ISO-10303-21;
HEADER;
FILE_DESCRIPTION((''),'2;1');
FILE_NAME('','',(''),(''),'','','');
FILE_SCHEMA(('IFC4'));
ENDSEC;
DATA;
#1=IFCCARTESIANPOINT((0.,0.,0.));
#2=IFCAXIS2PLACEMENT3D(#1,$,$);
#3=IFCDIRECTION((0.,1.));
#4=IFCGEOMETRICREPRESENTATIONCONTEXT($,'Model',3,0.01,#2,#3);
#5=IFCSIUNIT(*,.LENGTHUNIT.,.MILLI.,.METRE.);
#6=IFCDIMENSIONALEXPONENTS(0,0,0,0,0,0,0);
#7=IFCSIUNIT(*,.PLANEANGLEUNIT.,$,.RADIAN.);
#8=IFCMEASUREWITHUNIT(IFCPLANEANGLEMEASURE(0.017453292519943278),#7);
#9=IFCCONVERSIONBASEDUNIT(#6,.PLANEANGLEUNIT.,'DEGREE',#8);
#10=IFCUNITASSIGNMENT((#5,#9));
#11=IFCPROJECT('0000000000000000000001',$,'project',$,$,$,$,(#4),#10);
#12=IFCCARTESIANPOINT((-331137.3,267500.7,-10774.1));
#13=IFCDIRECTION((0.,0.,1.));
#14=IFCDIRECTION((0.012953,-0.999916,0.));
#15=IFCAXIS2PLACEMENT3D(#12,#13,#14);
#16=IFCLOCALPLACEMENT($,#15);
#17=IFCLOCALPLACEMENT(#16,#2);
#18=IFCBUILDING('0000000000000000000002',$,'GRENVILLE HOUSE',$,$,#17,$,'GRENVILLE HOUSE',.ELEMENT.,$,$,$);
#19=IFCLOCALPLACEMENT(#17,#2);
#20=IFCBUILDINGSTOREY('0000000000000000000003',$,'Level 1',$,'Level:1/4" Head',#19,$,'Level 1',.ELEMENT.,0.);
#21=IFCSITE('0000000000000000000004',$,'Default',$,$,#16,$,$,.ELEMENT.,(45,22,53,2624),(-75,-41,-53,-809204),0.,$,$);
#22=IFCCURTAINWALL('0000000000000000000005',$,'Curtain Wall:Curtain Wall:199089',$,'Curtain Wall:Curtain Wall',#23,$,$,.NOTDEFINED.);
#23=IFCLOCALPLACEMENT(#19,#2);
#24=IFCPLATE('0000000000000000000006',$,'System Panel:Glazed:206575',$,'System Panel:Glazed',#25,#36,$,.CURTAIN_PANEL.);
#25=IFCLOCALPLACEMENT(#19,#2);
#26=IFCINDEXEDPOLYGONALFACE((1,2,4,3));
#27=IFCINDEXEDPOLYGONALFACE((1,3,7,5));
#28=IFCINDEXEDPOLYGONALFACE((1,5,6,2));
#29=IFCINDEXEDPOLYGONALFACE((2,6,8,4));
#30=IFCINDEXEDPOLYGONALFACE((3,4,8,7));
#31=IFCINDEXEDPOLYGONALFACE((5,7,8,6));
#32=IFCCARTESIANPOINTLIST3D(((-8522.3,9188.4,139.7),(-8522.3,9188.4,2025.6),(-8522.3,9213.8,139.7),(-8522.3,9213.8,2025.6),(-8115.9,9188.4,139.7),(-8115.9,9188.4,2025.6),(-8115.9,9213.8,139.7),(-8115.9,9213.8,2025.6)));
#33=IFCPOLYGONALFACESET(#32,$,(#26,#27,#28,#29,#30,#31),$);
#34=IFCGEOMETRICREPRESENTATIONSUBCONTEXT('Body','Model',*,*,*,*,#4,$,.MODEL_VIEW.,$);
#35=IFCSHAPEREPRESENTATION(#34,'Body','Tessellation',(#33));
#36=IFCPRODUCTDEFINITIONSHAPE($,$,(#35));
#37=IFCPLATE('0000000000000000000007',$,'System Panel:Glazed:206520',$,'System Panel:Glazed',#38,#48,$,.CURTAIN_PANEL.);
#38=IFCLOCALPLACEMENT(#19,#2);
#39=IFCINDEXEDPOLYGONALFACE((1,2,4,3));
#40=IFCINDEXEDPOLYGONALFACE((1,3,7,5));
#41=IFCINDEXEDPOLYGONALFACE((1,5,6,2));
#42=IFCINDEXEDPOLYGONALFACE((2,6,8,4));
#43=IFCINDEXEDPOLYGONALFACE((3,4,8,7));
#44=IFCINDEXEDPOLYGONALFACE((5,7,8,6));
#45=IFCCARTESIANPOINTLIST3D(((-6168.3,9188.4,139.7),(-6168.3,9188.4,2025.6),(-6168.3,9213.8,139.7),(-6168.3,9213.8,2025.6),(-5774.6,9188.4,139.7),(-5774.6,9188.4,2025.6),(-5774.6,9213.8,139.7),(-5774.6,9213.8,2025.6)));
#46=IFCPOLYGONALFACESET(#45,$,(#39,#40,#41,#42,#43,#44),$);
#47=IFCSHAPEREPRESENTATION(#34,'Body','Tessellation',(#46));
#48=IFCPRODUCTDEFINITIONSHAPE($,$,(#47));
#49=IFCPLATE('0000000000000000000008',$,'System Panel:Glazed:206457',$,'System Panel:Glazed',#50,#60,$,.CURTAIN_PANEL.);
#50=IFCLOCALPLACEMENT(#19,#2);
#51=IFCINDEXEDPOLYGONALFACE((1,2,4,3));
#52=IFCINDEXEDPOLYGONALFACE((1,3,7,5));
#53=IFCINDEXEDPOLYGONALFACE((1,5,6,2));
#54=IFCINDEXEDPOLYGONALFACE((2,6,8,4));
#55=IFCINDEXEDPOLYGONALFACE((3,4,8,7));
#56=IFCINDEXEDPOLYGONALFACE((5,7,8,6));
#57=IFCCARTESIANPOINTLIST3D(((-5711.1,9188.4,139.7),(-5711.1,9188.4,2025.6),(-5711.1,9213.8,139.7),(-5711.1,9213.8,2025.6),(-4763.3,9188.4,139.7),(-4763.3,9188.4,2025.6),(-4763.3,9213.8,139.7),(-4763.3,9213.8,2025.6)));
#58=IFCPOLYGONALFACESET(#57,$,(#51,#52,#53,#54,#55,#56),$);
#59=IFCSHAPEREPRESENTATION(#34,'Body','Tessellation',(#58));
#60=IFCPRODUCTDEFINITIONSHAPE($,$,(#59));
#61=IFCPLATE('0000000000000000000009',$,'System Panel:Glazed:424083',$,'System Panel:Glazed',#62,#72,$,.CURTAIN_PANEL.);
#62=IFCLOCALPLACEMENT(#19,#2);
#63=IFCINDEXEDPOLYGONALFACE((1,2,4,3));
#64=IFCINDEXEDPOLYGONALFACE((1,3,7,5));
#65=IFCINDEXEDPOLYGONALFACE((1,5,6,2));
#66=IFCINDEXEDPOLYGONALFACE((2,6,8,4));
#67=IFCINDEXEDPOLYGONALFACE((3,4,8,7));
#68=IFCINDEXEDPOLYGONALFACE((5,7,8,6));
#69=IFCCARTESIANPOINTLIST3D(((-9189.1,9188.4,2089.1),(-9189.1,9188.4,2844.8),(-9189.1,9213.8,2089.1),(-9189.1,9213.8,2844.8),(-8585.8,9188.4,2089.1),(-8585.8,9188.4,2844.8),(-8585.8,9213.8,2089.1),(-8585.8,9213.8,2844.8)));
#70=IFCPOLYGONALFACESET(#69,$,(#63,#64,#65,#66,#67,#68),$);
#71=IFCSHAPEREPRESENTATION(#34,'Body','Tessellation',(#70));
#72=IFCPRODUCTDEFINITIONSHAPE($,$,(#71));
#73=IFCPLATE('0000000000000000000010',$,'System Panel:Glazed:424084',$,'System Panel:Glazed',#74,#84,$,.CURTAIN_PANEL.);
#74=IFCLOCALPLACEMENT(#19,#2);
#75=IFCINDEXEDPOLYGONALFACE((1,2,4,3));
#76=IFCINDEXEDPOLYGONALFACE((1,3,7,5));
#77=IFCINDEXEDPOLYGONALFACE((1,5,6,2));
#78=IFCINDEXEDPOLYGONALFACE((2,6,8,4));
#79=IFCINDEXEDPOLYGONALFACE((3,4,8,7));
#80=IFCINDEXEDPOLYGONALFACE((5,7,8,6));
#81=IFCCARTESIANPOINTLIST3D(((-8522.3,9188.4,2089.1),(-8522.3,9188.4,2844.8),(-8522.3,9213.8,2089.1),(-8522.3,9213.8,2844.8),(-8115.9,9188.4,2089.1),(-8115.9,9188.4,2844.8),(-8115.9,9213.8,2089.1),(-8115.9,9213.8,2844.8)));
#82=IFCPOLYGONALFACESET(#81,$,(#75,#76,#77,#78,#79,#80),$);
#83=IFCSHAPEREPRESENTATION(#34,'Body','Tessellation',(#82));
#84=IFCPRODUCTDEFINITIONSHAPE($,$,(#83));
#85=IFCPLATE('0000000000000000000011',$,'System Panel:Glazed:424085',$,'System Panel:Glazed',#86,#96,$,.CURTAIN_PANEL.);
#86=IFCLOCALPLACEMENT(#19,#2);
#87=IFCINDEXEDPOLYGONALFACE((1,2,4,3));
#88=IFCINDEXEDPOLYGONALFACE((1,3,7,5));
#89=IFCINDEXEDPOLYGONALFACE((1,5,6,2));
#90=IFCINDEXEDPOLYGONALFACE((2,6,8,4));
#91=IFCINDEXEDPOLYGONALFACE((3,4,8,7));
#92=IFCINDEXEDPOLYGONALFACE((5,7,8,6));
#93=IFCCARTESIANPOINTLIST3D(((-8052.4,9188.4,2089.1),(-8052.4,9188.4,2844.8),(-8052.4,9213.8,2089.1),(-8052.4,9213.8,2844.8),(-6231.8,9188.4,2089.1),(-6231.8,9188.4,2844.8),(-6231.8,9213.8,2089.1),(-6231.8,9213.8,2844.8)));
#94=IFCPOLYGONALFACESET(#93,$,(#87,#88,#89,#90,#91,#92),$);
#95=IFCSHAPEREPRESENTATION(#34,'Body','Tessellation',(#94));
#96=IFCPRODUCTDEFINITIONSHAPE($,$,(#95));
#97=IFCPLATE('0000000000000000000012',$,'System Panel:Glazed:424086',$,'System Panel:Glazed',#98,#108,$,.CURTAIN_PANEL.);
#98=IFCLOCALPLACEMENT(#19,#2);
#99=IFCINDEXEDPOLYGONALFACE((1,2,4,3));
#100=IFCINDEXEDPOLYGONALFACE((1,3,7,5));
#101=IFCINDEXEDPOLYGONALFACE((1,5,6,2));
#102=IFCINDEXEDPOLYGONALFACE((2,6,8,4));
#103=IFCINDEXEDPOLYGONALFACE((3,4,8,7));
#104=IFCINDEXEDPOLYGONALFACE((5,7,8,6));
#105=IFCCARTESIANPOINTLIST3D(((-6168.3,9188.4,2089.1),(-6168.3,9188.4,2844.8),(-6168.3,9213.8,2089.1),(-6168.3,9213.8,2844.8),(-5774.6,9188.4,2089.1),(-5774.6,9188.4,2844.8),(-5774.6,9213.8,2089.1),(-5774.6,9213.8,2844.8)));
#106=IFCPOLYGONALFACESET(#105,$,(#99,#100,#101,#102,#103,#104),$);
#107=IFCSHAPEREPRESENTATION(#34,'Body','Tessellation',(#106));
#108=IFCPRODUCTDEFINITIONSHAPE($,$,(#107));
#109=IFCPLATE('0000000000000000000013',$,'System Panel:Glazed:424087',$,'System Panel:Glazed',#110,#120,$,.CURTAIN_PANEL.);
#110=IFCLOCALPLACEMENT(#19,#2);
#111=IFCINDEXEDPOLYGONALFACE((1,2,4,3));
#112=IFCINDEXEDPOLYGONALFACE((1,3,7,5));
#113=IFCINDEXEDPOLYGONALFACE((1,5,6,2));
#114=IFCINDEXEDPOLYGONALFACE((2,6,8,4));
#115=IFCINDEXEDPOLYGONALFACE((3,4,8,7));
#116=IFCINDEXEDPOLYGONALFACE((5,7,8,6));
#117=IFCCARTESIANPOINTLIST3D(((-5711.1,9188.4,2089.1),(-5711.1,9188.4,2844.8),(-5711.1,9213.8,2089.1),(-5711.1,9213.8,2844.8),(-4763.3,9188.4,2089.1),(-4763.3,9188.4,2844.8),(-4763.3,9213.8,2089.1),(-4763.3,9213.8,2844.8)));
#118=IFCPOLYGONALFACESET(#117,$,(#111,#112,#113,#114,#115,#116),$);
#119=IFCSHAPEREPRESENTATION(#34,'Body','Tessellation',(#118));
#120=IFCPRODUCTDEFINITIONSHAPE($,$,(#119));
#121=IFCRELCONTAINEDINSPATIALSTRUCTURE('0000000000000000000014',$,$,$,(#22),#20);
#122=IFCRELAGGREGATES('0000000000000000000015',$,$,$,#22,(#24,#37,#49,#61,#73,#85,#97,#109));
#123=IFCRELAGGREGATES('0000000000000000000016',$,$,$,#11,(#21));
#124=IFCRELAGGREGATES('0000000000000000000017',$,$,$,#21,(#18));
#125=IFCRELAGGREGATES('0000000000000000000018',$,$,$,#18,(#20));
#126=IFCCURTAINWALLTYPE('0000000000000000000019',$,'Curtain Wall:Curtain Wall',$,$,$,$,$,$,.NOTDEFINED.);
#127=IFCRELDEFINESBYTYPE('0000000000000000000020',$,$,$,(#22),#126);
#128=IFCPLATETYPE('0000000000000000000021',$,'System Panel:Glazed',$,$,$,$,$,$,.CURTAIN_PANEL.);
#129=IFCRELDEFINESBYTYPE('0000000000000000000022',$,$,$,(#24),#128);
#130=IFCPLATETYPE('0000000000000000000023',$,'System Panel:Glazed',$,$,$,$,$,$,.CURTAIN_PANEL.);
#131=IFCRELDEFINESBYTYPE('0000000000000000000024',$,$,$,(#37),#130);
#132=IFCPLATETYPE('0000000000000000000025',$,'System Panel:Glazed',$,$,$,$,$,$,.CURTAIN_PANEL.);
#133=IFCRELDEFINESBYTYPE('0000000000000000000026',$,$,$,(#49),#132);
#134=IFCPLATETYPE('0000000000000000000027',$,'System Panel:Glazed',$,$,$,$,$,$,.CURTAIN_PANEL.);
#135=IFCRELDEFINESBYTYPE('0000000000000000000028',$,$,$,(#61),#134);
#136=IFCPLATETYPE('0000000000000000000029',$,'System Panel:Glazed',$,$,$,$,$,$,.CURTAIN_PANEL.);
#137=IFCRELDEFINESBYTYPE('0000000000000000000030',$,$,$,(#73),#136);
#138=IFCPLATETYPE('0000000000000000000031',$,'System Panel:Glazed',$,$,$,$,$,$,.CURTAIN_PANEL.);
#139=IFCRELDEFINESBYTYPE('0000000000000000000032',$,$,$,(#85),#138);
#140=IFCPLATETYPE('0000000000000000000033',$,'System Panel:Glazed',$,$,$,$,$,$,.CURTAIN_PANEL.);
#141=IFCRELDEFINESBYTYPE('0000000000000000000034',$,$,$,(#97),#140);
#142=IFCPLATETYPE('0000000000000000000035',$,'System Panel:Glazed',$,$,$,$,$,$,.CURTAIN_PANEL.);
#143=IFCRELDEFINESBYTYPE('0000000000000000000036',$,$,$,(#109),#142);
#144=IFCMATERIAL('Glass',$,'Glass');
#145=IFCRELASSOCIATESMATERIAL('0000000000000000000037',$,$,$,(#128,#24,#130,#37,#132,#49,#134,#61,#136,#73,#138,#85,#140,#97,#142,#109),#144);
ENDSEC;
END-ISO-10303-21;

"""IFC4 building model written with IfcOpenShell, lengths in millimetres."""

from ifc_helpers import new_model, entity, si_unit, converted_unit, direction, frame, origin, place, context, subcontext, project, spatial, indexed_curve, outline, extrude, source, transform, mapped, material, type_object, type_shapes, element, aggregate, save


model = new_model("IFC4")

# Units and contexts
model_context = context("Model", 3, precision=0.01, world=origin(), true_north=direction((0.0, 1.0)))
body_context = subcontext(model_context, "Body", "Model", "MODEL_VIEW")
ifc_project = project(units=[si_unit("LENGTHUNIT", "METRE", prefix="MILLI"), converted_unit("PLANEANGLEUNIT", "DEGREE", entity("IfcPlaneAngleMeasure", 0.017453292519943278), si_unit("PLANEANGLEUNIT", "RADIAN"), dimensions=[0, 0, 0, 0, 0, 0, 0])], contexts=[model_context])

# Site, building, storey
site_placement = place(None, frame((-331137.3, 267500.7, -10774.1), z_axis=(0.0, 0.0, 1.0), x_axis=(0.012953, -0.999916, 0.0)))
site = spatial("IfcSite", under=ifc_project, at=site_placement, Name="Default", CompositionType="ELEMENT", RefLatitude=(45, 22, 53, 2624), RefLongitude=(-75, -41, -53, -809204), RefElevation=0.0)
building_placement = place(site_placement, origin())
building = spatial("IfcBuilding", under=site, at=building_placement, Name="GRENVILLE HOUSE", LongName="GRENVILLE HOUSE", CompositionType="ELEMENT")
storey_placement = place(building_placement, origin())
storey = spatial("IfcBuildingStorey", under=building, at=storey_placement, Name="Level 1", ObjectType="Level:1/4\" Head", LongName="Level 1", CompositionType="ELEMENT", Elevation=0.0)

# Shared definitions
curtain_wall_type = type_object("IfcCurtainWallType", Name="Curtain Wall:Curtain Wall", PredefinedType="NOTDEFINED")

# Curtain wall, plates
curtain_wall_1_placement = place(storey_placement, origin())
curtain_wall_1 = element("IfcCurtainWall", 1, at=curtain_wall_1_placement, inside=storey, type_object=curtain_wall_type, Name="Curtain Wall:Curtain Wall:199089", ObjectType="Curtain Wall:Curtain Wall", PredefinedType="NOTDEFINED")
ifc_material_1 = material(Name="Glass", Category="Glass")
plate_type_1 = type_object("IfcPlateType", Name="System Panel:Glazed", PredefinedType="CURTAIN_PANEL", material=ifc_material_1)
shared_shape_1 = source(origin(), body_context, "Body", "SweptSolid", [
    extrude(outline(indexed_curve([(-12.7, -203.2), (12.7, -203.2), (12.7, 203.2), (-12.7, 203.2), (-12.7, -203.2)], self_intersect=False)), frame((203.2, 12.7, 0.0), z_axis=(0.0, 0.0, 1.0), x_axis=(0.0, 1.0, 0.0)), (0.0, 0.0, 1.0), 1885.9),
])
type_shapes(plate_type_1, [shared_shape_1])
plate_1_placement = place(curtain_wall_1_placement, frame((-8522.3, 9188.4, 139.7)))
plate_1 = element("IfcPlate", 2, at=plate_1_placement, type_object=plate_type_1, material=ifc_material_1, Name="System Panel:Glazed:206575", ObjectType="System Panel:Glazed", PredefinedType="CURTAIN_PANEL", context=body_context, shape_type="MappedRepresentation", body=[
    mapped(shared_shape_1, transform((0.0, 0.0, 0.0), scale=1.0)),
])
plate_type_2 = type_object("IfcPlateType", Name="System Panel:Glazed", PredefinedType="CURTAIN_PANEL", material=ifc_material_1)
shared_shape_2 = source(origin(), body_context, "Body", "SweptSolid", [
    extrude(outline(indexed_curve([(-12.7, -196.8), (12.7, -196.8), (12.7, 196.8), (-12.7, 196.8), (-12.7, -196.8)], self_intersect=False)), frame((196.8, 12.7, 0.0), z_axis=(0.0, 0.0, 1.0), x_axis=(0.0, 1.0, 0.0)), (0.0, 0.0, 1.0), 1885.9),
])
type_shapes(plate_type_2, [shared_shape_2])
plate_2_placement = place(curtain_wall_1_placement, frame((-6168.3, 9188.4, 139.7)))
plate_2 = element("IfcPlate", 3, at=plate_2_placement, type_object=plate_type_2, material=ifc_material_1, Name="System Panel:Glazed:206520", ObjectType="System Panel:Glazed", PredefinedType="CURTAIN_PANEL", context=body_context, shape_type="MappedRepresentation", body=[
    mapped(shared_shape_2, transform((0.0, 0.0, 0.0), scale=1.0)),
])
plate_type_3 = type_object("IfcPlateType", Name="System Panel:Glazed", PredefinedType="CURTAIN_PANEL", material=ifc_material_1)
shared_shape_3 = source(origin(), body_context, "Body", "SweptSolid", [
    extrude(outline(indexed_curve([(-12.7, -473.9), (12.7, -473.9), (12.7, 473.9), (-12.7, 473.9), (-12.7, -473.9)], self_intersect=False)), frame((473.9, 12.7, 0.0), z_axis=(0.0, 0.0, 1.0), x_axis=(0.0, 1.0, 0.0)), (0.0, 0.0, 1.0), 1885.9),
])
type_shapes(plate_type_3, [shared_shape_3])
plate_3_placement = place(curtain_wall_1_placement, frame((-5711.1, 9188.4, 139.7)))
plate_3 = element("IfcPlate", 4, at=plate_3_placement, type_object=plate_type_3, material=ifc_material_1, Name="System Panel:Glazed:206457", ObjectType="System Panel:Glazed", PredefinedType="CURTAIN_PANEL", context=body_context, shape_type="MappedRepresentation", body=[
    mapped(shared_shape_3, transform((0.0, 0.0, 0.0), scale=1.0)),
])
plate_type_4 = type_object("IfcPlateType", Name="System Panel:Glazed", PredefinedType="CURTAIN_PANEL", material=ifc_material_1)
shared_shape_4 = source(origin(), body_context, "Body", "SweptSolid", [
    extrude(outline(indexed_curve([(-12.7, -301.6), (12.7, -301.6), (12.7, 301.6), (-12.7, 301.6), (-12.7, -301.6)], self_intersect=False)), frame((301.6, 12.7, 0.0), z_axis=(0.0, 0.0, 1.0), x_axis=(0.0, 1.0, 0.0)), (0.0, 0.0, 1.0), 755.6),
])
type_shapes(plate_type_4, [shared_shape_4])
plate_4_placement = place(curtain_wall_1_placement, frame((-9189.1, 9188.4, 2089.1)))
plate_4 = element("IfcPlate", 5, at=plate_4_placement, type_object=plate_type_4, material=ifc_material_1, Name="System Panel:Glazed:424083", ObjectType="System Panel:Glazed", PredefinedType="CURTAIN_PANEL", context=body_context, shape_type="MappedRepresentation", body=[
    mapped(shared_shape_4, transform((0.0, 0.0, 0.0), scale=1.0)),
])
plate_type_5 = type_object("IfcPlateType", Name="System Panel:Glazed", PredefinedType="CURTAIN_PANEL", material=ifc_material_1)
shared_shape_5 = source(origin(), body_context, "Body", "SweptSolid", [
    extrude(outline(indexed_curve([(-12.7, -203.2), (12.7, -203.2), (12.7, 203.2), (-12.7, 203.2), (-12.7, -203.2)], self_intersect=False)), frame((203.2, 12.7, 0.0), z_axis=(0.0, 0.0, 1.0), x_axis=(0.0, 1.0, 0.0)), (0.0, 0.0, 1.0), 755.6),
])
type_shapes(plate_type_5, [shared_shape_5])
plate_5_placement = place(curtain_wall_1_placement, frame((-8522.3, 9188.4, 2089.1)))
plate_5 = element("IfcPlate", 6, at=plate_5_placement, type_object=plate_type_5, material=ifc_material_1, Name="System Panel:Glazed:424084", ObjectType="System Panel:Glazed", PredefinedType="CURTAIN_PANEL", context=body_context, shape_type="MappedRepresentation", body=[
    mapped(shared_shape_5, transform((0.0, 0.0, 0.0), scale=1.0)),
])
plate_type_6 = type_object("IfcPlateType", Name="System Panel:Glazed", PredefinedType="CURTAIN_PANEL", material=ifc_material_1)
shared_shape_6 = source(origin(), body_context, "Body", "SweptSolid", [
    extrude(outline(indexed_curve([(-12.7, -910.3), (12.7, -910.3), (12.7, 910.3), (-12.7, 910.3), (-12.7, -910.3)], self_intersect=False)), frame((910.3, 12.7, 0.0), z_axis=(0.0, 0.0, 1.0), x_axis=(0.0, 1.0, 0.0)), (0.0, 0.0, 1.0), 755.6),
])
type_shapes(plate_type_6, [shared_shape_6])
plate_6_placement = place(curtain_wall_1_placement, frame((-8052.4, 9188.4, 2089.1)))
plate_6 = element("IfcPlate", 7, at=plate_6_placement, type_object=plate_type_6, material=ifc_material_1, Name="System Panel:Glazed:424085", ObjectType="System Panel:Glazed", PredefinedType="CURTAIN_PANEL", context=body_context, shape_type="MappedRepresentation", body=[
    mapped(shared_shape_6, transform((0.0, 0.0, 0.0), scale=1.0)),
])
plate_type_7 = type_object("IfcPlateType", Name="System Panel:Glazed", PredefinedType="CURTAIN_PANEL", material=ifc_material_1)
shared_shape_7 = source(origin(), body_context, "Body", "SweptSolid", [
    extrude(outline(indexed_curve([(-12.7, -196.8), (12.7, -196.8), (12.7, 196.8), (-12.7, 196.8), (-12.7, -196.8)], self_intersect=False)), frame((196.8, 12.7, 0.0), z_axis=(0.0, 0.0, 1.0), x_axis=(0.0, 1.0, 0.0)), (0.0, 0.0, 1.0), 755.6),
])
type_shapes(plate_type_7, [shared_shape_7])
plate_7_placement = place(curtain_wall_1_placement, frame((-6168.3, 9188.4, 2089.1)))
plate_7 = element("IfcPlate", 8, at=plate_7_placement, type_object=plate_type_7, material=ifc_material_1, Name="System Panel:Glazed:424086", ObjectType="System Panel:Glazed", PredefinedType="CURTAIN_PANEL", context=body_context, shape_type="MappedRepresentation", body=[
    mapped(shared_shape_7, transform((0.0, 0.0, 0.0), scale=1.0)),
])
plate_type_8 = type_object("IfcPlateType", Name="System Panel:Glazed", PredefinedType="CURTAIN_PANEL", material=ifc_material_1)
shared_shape_8 = source(origin(), body_context, "Body", "SweptSolid", [
    extrude(outline(indexed_curve([(-12.7, -473.9), (12.7, -473.9), (12.7, 473.9), (-12.7, 473.9), (-12.7, -473.9)], self_intersect=False)), frame((473.9, 12.7, 0.0), z_axis=(0.0, 0.0, 1.0), x_axis=(0.0, 1.0, 0.0)), (0.0, 0.0, 1.0), 755.6),
])
type_shapes(plate_type_8, [shared_shape_8])
plate_8_placement = place(curtain_wall_1_placement, frame((-5711.1, 9188.4, 2089.1)))
plate_8 = element("IfcPlate", 9, at=plate_8_placement, type_object=plate_type_8, material=ifc_material_1, Name="System Panel:Glazed:424087", ObjectType="System Panel:Glazed", PredefinedType="CURTAIN_PANEL", context=body_context, shape_type="MappedRepresentation", body=[
    mapped(shared_shape_8, transform((0.0, 0.0, 0.0), scale=1.0)),
])

aggregate(curtain_wall_1, [plate_1, plate_2, plate_3, plate_4, plate_5, plate_6, plate_7, plate_8])

save(model, "model.ifc")
